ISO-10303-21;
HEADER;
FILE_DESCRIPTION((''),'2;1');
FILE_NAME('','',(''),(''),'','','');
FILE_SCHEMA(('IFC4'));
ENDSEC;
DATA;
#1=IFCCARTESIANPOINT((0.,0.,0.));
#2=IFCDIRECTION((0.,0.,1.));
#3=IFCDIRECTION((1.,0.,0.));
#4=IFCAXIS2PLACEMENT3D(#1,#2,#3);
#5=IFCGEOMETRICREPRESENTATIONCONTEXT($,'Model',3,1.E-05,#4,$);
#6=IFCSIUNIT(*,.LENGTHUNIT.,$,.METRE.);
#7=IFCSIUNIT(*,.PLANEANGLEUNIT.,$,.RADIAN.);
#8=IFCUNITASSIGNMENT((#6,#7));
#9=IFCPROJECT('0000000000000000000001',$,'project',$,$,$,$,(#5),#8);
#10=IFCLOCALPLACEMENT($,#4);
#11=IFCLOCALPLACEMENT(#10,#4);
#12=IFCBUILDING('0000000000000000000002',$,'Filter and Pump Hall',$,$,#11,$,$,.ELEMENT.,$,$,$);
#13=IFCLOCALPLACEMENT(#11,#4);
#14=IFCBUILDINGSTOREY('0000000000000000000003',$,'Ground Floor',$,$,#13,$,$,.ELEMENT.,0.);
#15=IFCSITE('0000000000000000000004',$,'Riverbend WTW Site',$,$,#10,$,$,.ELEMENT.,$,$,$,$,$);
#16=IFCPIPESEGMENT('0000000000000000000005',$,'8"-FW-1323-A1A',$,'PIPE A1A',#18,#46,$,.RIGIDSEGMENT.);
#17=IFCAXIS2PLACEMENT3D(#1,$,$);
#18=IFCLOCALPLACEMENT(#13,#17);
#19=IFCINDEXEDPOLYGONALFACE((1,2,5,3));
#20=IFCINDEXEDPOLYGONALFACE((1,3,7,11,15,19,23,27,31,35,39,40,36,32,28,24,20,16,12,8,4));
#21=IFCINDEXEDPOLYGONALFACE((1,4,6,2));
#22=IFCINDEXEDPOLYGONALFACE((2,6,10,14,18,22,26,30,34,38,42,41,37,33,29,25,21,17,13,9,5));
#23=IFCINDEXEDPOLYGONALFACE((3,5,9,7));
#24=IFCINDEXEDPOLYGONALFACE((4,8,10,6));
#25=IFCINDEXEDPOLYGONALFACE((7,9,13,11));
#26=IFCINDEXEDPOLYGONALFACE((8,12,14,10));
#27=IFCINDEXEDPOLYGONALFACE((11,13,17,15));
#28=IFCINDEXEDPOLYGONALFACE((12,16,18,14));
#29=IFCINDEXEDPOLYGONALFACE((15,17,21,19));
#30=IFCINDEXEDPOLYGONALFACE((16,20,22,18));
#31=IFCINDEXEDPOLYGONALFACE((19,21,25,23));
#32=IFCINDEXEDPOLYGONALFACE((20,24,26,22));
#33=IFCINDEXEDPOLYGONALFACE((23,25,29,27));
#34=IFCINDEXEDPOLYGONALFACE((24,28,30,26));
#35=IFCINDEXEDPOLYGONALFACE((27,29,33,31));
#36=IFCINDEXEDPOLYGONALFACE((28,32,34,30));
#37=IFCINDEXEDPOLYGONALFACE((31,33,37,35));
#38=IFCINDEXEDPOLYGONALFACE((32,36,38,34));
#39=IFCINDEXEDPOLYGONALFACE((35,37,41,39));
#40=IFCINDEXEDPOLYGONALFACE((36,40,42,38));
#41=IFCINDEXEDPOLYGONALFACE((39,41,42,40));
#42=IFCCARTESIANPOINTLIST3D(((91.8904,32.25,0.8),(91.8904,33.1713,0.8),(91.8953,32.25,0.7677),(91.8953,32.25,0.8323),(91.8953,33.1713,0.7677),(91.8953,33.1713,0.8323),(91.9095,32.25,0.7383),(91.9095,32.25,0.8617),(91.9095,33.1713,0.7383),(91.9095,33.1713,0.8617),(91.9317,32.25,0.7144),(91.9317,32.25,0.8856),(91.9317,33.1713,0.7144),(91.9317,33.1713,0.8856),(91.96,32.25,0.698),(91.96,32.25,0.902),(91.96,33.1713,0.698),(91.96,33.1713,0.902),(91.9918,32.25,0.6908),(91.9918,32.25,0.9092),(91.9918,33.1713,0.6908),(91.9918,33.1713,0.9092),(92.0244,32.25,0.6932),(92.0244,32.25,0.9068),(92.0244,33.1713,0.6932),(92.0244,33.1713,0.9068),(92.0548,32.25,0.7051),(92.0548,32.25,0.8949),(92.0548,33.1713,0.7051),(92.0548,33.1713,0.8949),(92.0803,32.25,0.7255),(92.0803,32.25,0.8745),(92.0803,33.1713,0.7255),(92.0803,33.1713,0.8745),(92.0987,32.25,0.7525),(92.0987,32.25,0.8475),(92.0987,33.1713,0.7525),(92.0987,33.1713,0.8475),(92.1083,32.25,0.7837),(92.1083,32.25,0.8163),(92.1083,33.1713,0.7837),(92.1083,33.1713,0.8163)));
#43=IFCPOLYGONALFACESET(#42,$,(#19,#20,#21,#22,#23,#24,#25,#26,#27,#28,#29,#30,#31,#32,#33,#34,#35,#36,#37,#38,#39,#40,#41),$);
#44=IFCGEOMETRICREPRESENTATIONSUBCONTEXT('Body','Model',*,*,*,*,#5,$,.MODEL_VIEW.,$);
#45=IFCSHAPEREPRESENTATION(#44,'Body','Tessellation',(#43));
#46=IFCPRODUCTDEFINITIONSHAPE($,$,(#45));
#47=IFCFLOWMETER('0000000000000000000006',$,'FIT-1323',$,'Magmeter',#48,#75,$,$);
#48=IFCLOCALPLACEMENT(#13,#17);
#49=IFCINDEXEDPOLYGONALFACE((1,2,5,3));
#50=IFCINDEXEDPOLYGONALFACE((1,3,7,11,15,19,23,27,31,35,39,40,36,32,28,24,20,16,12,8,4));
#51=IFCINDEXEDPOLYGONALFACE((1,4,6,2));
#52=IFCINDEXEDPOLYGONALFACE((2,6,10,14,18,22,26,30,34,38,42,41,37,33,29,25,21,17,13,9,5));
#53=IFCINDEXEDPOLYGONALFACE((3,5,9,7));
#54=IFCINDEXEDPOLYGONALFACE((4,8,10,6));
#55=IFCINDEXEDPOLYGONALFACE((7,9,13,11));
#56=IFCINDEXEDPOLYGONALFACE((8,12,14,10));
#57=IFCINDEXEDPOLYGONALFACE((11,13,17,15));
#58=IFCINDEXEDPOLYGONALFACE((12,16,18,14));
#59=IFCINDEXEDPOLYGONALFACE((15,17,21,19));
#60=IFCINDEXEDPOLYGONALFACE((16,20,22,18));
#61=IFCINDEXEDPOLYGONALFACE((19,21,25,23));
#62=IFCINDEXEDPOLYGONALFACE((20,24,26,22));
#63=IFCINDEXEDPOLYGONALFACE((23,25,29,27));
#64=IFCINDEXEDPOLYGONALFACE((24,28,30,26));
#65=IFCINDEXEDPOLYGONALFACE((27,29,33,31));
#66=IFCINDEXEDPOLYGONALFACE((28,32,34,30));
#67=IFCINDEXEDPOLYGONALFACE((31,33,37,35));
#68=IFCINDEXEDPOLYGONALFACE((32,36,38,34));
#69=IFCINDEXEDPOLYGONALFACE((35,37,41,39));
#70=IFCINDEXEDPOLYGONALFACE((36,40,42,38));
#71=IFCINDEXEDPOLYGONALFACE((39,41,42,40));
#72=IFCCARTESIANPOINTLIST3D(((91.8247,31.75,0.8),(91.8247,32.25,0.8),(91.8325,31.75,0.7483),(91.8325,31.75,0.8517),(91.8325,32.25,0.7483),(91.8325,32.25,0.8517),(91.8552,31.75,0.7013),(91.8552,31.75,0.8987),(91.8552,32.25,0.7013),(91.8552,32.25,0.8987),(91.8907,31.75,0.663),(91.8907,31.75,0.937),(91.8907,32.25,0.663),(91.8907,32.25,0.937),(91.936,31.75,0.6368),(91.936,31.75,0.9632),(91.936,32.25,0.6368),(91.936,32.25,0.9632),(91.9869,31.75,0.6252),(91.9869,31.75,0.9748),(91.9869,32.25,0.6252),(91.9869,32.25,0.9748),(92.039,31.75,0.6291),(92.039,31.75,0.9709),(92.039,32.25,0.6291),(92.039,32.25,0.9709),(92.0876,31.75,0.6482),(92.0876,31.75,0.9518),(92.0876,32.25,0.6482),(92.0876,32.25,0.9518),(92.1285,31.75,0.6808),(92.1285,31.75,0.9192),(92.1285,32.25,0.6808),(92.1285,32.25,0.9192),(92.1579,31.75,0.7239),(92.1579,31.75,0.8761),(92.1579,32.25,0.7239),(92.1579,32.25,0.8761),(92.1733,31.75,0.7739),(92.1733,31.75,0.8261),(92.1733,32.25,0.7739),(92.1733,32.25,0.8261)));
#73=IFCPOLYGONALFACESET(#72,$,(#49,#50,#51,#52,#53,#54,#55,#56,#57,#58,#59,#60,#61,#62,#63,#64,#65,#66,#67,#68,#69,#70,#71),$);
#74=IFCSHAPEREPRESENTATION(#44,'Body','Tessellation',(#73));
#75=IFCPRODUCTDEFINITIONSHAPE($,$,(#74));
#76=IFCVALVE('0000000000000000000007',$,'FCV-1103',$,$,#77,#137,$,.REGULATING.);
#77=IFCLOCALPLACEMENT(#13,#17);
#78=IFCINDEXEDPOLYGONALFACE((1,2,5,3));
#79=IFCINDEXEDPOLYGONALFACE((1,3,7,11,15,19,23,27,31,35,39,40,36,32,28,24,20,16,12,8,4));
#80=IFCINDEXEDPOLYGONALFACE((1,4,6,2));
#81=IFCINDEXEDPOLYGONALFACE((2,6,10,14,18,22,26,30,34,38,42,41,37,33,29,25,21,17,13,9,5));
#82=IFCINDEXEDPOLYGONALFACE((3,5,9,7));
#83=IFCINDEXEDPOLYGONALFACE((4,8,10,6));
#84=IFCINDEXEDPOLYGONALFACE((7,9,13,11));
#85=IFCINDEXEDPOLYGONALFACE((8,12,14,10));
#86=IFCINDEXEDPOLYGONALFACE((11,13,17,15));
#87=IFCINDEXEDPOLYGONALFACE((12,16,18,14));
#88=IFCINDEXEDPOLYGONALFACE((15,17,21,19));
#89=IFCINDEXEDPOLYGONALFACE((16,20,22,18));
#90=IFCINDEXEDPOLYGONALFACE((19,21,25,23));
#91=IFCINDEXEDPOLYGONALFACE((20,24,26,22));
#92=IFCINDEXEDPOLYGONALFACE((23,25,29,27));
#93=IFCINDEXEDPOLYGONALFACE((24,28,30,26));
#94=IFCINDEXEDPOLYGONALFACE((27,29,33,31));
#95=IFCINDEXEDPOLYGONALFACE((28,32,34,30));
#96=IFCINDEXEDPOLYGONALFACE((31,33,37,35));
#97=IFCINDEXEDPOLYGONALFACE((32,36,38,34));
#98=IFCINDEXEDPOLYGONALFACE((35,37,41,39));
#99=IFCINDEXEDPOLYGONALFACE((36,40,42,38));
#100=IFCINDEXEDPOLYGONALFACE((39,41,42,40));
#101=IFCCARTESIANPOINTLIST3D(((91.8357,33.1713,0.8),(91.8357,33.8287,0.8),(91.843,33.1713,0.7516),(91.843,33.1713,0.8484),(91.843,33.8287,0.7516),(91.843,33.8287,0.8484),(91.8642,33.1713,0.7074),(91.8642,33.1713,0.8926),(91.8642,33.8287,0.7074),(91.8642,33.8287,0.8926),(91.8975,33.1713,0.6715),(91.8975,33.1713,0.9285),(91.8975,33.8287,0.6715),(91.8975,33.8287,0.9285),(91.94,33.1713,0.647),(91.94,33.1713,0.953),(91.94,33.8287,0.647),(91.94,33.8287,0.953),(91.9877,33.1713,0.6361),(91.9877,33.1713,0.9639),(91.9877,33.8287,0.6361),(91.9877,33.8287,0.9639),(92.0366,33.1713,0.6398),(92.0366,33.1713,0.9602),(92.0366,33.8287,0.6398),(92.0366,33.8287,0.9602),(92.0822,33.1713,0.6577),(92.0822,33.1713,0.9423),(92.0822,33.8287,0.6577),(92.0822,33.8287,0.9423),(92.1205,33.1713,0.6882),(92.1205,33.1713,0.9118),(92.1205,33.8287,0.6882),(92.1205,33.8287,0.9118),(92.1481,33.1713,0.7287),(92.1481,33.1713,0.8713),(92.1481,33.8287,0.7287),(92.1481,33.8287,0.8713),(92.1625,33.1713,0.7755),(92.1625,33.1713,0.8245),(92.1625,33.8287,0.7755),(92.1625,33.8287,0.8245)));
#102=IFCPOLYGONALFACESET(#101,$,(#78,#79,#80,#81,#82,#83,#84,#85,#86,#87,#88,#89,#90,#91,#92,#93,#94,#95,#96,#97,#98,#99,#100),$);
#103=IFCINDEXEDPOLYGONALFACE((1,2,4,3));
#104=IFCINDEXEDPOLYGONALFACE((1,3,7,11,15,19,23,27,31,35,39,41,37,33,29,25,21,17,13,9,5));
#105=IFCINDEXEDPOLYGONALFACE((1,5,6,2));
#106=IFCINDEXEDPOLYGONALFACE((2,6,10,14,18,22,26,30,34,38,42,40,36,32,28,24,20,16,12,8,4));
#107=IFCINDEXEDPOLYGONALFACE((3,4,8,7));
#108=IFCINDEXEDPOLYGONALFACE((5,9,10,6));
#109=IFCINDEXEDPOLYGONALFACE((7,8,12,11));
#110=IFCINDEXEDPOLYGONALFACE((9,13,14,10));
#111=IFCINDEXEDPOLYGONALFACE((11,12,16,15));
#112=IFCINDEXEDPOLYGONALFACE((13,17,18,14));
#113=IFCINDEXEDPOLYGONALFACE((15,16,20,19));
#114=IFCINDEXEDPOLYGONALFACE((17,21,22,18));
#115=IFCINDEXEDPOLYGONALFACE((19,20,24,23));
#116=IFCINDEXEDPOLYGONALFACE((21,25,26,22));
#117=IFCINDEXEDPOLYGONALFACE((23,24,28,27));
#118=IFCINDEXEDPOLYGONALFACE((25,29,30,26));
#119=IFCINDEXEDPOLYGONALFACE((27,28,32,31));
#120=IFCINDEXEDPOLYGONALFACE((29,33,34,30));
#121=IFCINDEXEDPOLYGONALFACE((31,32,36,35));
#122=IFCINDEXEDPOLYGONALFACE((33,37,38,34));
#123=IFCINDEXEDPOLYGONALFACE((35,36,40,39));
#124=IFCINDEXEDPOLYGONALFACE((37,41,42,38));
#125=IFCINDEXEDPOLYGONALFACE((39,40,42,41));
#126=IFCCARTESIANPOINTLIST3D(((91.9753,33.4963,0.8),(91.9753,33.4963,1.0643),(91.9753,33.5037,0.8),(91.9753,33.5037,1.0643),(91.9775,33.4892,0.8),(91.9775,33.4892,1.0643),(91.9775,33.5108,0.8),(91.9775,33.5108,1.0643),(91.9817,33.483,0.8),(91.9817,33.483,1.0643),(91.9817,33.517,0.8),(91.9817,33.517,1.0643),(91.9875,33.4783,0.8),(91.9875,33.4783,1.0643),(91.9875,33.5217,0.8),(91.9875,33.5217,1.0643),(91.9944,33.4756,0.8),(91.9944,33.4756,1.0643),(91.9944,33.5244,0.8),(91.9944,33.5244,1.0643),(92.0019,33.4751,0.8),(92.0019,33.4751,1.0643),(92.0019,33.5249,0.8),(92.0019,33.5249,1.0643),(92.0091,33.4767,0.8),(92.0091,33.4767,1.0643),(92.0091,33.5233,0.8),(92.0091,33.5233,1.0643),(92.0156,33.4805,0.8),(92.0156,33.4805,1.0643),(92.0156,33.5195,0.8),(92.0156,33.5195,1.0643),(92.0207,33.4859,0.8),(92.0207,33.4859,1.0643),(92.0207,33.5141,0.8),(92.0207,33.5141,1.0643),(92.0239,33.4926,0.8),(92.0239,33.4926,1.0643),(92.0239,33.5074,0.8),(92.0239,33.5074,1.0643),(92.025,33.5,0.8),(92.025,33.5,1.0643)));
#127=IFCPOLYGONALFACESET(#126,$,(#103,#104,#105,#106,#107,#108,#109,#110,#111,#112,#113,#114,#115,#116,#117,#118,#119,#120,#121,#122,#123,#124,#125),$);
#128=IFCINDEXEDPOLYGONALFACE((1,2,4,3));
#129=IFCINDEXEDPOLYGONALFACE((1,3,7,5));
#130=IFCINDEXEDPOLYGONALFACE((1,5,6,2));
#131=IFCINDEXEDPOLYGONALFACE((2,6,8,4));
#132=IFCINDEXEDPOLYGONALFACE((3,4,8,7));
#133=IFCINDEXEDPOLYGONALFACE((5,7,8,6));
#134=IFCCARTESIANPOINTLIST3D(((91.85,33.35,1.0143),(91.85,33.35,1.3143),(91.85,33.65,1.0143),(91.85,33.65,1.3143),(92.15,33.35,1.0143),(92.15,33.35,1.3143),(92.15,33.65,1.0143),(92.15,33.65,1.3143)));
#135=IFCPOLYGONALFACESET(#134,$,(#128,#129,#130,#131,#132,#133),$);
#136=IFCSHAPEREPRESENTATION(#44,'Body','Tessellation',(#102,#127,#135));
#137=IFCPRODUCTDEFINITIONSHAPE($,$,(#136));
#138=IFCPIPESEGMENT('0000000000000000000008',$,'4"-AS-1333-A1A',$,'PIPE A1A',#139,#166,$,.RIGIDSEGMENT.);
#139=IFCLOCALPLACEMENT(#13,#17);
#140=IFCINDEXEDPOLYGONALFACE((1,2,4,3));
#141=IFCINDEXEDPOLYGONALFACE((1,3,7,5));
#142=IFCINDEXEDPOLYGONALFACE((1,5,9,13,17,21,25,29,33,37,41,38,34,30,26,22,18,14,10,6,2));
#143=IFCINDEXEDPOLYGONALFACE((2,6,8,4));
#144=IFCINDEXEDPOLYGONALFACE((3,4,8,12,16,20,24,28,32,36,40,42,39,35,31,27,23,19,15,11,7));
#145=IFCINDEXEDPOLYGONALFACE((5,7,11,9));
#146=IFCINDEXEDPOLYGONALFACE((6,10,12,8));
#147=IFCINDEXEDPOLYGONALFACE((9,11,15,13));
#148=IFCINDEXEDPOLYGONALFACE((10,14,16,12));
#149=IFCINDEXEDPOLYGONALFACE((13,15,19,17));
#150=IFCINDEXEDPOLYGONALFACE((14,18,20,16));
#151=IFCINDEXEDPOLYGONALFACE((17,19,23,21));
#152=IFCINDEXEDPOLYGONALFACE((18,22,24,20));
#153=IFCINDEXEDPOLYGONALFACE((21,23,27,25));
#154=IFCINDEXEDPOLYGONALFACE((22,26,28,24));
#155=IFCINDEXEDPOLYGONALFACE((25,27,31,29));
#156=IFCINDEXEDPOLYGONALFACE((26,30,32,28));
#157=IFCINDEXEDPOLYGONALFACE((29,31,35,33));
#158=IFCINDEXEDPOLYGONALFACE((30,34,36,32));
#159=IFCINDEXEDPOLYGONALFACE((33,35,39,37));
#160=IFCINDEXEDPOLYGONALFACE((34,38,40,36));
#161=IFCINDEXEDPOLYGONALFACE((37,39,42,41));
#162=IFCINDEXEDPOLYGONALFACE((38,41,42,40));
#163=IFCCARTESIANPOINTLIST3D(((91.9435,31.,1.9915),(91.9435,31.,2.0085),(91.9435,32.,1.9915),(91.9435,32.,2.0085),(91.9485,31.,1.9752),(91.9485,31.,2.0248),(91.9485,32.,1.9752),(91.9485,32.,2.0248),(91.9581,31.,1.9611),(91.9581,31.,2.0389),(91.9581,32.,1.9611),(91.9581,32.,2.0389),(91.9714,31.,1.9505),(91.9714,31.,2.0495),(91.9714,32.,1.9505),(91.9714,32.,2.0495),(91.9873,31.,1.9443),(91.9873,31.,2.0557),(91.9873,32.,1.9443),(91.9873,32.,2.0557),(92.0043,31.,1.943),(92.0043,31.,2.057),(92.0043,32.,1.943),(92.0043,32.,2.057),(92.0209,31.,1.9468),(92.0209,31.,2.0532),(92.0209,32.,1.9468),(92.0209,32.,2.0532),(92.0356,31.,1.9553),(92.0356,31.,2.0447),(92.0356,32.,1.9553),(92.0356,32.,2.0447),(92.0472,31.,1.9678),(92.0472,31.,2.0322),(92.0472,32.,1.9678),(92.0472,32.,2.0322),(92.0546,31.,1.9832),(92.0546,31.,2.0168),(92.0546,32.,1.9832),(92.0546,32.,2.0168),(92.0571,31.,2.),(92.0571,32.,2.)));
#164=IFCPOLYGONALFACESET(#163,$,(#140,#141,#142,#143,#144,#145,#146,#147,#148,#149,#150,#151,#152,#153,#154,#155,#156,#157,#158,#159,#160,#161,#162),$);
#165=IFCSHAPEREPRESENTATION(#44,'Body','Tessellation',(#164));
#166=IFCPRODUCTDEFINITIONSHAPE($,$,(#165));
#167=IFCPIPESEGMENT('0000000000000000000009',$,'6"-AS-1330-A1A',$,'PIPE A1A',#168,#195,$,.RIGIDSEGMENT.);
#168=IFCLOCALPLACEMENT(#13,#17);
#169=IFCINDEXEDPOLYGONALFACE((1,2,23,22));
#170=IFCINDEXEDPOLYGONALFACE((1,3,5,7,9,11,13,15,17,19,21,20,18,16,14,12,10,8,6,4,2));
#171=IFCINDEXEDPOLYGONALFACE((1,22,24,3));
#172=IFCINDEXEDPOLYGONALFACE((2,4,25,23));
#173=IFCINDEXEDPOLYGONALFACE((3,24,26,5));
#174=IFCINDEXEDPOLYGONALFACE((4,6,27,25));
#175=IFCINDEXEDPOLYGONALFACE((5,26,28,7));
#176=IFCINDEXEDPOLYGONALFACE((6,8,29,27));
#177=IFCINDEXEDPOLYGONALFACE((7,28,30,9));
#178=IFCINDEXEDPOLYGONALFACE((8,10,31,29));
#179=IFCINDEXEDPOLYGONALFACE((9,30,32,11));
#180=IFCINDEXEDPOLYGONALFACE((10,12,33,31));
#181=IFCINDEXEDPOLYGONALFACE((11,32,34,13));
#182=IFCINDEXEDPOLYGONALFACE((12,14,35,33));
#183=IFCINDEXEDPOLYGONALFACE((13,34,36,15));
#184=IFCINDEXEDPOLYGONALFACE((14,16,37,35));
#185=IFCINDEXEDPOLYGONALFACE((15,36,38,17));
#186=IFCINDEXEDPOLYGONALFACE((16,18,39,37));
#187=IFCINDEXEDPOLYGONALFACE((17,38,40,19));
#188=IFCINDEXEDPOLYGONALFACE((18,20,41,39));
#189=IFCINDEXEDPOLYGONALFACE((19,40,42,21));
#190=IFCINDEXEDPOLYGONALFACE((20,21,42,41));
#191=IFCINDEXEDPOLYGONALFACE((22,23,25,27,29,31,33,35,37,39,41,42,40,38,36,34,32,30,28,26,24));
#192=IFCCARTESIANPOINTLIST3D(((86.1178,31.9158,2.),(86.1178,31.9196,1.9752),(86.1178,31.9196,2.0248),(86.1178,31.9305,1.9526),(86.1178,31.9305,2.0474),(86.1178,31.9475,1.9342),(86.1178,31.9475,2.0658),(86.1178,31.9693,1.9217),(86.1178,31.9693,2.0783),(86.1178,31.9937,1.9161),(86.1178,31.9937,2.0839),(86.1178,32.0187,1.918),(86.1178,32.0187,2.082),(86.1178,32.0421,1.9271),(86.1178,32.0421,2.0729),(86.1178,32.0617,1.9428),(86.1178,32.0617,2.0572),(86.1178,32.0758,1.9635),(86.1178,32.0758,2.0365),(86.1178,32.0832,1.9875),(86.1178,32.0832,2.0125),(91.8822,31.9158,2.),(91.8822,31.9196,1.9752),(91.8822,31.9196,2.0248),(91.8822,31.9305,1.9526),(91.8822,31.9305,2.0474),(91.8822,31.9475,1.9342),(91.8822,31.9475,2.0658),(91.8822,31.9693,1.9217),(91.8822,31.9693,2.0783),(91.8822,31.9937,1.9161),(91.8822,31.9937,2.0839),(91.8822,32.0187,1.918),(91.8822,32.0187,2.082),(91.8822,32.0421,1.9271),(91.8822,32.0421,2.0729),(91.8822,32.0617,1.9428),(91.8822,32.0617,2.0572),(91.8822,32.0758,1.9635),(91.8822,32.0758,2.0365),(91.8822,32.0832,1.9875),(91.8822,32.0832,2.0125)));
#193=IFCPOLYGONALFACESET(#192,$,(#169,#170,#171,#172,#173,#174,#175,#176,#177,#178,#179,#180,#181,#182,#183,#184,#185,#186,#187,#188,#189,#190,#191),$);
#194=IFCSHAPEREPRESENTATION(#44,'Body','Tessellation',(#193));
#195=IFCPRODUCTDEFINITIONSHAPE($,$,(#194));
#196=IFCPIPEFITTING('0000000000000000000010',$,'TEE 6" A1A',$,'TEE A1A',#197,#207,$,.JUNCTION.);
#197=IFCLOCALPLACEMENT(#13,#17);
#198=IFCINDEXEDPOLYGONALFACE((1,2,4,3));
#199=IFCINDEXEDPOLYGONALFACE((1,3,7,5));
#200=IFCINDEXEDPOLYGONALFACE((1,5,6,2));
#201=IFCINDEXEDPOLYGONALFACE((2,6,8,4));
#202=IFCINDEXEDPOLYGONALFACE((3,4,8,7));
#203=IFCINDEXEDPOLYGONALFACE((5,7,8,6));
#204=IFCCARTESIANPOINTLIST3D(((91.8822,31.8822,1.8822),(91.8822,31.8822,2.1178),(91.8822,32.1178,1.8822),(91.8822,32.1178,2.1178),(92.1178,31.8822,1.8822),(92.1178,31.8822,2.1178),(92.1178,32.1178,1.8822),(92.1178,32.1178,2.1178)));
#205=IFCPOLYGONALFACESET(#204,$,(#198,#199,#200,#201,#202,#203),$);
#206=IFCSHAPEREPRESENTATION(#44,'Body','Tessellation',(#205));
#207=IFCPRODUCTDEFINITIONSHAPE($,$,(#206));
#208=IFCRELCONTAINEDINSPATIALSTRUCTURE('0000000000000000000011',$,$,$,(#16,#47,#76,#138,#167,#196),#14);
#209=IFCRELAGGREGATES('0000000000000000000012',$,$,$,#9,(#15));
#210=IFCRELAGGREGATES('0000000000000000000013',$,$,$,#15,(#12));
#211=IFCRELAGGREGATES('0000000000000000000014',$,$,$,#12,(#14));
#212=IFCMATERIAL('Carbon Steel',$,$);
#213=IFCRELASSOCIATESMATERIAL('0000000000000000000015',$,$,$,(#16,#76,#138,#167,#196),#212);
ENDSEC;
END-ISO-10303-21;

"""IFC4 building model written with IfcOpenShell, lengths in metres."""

from ifc_helpers import new_model, si_unit, frame, origin_with_axes, origin_2d, place, context, subcontext, project, spatial, rectangle, circle, extrude, material, element, save


model = new_model("IFC4")

# Units and contexts
model_context = context("Model", 3, precision=1e-05, world=origin_with_axes())
body_context = subcontext(model_context, "Body", "Model", "MODEL_VIEW")
ifc_project = project(units=[si_unit("LENGTHUNIT", "METRE"), si_unit("PLANEANGLEUNIT", "RADIAN")], contexts=[model_context])

# Site, building, storey
site_placement = place(None, origin_with_axes())
site = spatial("IfcSite", under=ifc_project, at=site_placement, Name="Riverbend WTW Site", CompositionType="ELEMENT")
building_placement = place(site_placement, origin_with_axes())
building = spatial("IfcBuilding", under=site, at=building_placement, Name="Filter and Pump Hall", CompositionType="ELEMENT")
storey_placement = place(building_placement, origin_with_axes())
storey = spatial("IfcBuildingStorey", under=building, at=storey_placement, Name="Ground Floor", CompositionType="ELEMENT", Elevation=0.0)

# Shared definitions
ifc_material_1 = material(Name="Carbon Steel")

# Pipe segment
pipe_segment_1_placement = place(None, frame((92.0, 32.25, 0.8), z_axis=(0.0, 0.0, 1.0), x_axis=(1.0, 0.0, 0.0)))
element("IfcPipeSegment", 1, at=pipe_segment_1_placement, inside=storey, material=ifc_material_1, Name="8\"-FW-1323-A1A", ObjectType="PIPE A1A", PredefinedType="RIGIDSEGMENT", context=body_context, shape_type="SweptSolid", body=[
    extrude(circle(Radius=0.1095, at=origin_2d()), frame((0.0, 0.0, 0.0), z_axis=(0.0, 1.0, 0.0), x_axis=(-1.0, 0.0, 0.0)), (0.0, 0.0, 1.0), 0.9213),
])

# Flow meter
flow_meter_placement = place(None, frame((92.0, 31.75, 0.8), z_axis=(0.0, 0.0, 1.0), x_axis=(1.0, 0.0, 0.0)))
element("IfcFlowMeter", 2, at=flow_meter_placement, inside=storey, Name="FIT-1323", ObjectType="Magmeter", context=body_context, shape_type="SweptSolid", body=[
    extrude(circle(Radius=0.1753, at=origin_2d()), frame((0.0, 0.0, 0.0), z_axis=(0.0, 1.0, 0.0), x_axis=(-1.0, 0.0, 0.0)), (0.0, 0.0, 1.0), 0.5),
])

# Valve
valve_1_placement = place(None, frame((92.0, 33.1713, 0.8), z_axis=(0.0, 0.0, 1.0), x_axis=(1.0, 0.0, 0.0)))
element("IfcValve", 3, at=valve_1_placement, inside=storey, material=ifc_material_1, Name="FCV-1103", PredefinedType="REGULATING", context=body_context, shape_type="SweptSolid", body=[
    extrude(circle(Radius=0.1643, at=origin_2d()), frame((0.0, 0.0, 0.0), z_axis=(0.0, 1.0, 0.0), x_axis=(-1.0, 0.0, 0.0)), (0.0, 0.0, 1.0), 0.6573),
    extrude(circle(Radius=0.025, at=origin_2d()), frame((0.0, 0.3287, 0.0), z_axis=(0.0, 0.0, 1.0), x_axis=(1.0, 0.0, 0.0)), (0.0, 0.0, 1.0), 0.2643),
    extrude(rectangle(XDim=0.3, YDim=0.3, at=origin_2d()), frame((0.0, 0.3287, 0.2143), z_axis=(0.0, 0.0, 1.0), x_axis=(1.0, 0.0, 0.0)), (0.0, 0.0, 1.0), 0.3),
])

# Pipe segments
pipe_segment_2_placement = place(None, frame((92.0, 32.0, 2.0), z_axis=(0.0, 0.0, 1.0), x_axis=(1.0, 0.0, 0.0)))
element("IfcPipeSegment", 4, at=pipe_segment_2_placement, inside=storey, material=ifc_material_1, Name="4\"-AS-1333-A1A", ObjectType="PIPE A1A", PredefinedType="RIGIDSEGMENT", context=body_context, shape_type="SweptSolid", body=[
    extrude(circle(Radius=0.0571, at=origin_2d()), frame((0.0, 0.0, 0.0), z_axis=(0.0, -1.0, 0.0), x_axis=(1.0, 0.0, 0.0)), (0.0, 0.0, 1.0), 1.0),
])
pipe_segment_3_placement = place(None, frame((91.8822, 32.0, 2.0), z_axis=(0.0, 0.0, 1.0), x_axis=(1.0, 0.0, 0.0)))
element("IfcPipeSegment", 5, at=pipe_segment_3_placement, inside=storey, material=ifc_material_1, Name="6\"-AS-1330-A1A", ObjectType="PIPE A1A", PredefinedType="RIGIDSEGMENT", context=body_context, shape_type="SweptSolid", body=[
    extrude(circle(Radius=0.0842, at=origin_2d()), frame((0.0, 0.0, 0.0), z_axis=(-1.0, 0.0, 0.0), x_axis=(0.0, -1.0, 0.0)), (0.0, 0.0, 1.0), 5.7644),
])

# Pipe fitting
for number, where, z_axis, x_axis, name in (
    (6, (92.0, 32.0, 2.0), (0.0, 0.0, 1.0), (1.0, 0.0, 0.0), "TEE 6\" A1A"),
):
    element("IfcPipeFitting", number, at=place(None, frame(where, z_axis=z_axis, x_axis=x_axis)), inside=storey, material=ifc_material_1, Name=name, ObjectType="TEE A1A", PredefinedType="JUNCTION", context=body_context, shape_type="SweptSolid", body=[
        extrude(rectangle(XDim=0.2356, YDim=0.2356, at=origin_2d()), frame((0.0, 0.0, -0.1178), z_axis=(0.0, 0.0, 1.0), x_axis=(1.0, 0.0, 0.0)), (0.0, 0.0, 1.0), 0.2356),
    ])

save(model, "model.ifc")
